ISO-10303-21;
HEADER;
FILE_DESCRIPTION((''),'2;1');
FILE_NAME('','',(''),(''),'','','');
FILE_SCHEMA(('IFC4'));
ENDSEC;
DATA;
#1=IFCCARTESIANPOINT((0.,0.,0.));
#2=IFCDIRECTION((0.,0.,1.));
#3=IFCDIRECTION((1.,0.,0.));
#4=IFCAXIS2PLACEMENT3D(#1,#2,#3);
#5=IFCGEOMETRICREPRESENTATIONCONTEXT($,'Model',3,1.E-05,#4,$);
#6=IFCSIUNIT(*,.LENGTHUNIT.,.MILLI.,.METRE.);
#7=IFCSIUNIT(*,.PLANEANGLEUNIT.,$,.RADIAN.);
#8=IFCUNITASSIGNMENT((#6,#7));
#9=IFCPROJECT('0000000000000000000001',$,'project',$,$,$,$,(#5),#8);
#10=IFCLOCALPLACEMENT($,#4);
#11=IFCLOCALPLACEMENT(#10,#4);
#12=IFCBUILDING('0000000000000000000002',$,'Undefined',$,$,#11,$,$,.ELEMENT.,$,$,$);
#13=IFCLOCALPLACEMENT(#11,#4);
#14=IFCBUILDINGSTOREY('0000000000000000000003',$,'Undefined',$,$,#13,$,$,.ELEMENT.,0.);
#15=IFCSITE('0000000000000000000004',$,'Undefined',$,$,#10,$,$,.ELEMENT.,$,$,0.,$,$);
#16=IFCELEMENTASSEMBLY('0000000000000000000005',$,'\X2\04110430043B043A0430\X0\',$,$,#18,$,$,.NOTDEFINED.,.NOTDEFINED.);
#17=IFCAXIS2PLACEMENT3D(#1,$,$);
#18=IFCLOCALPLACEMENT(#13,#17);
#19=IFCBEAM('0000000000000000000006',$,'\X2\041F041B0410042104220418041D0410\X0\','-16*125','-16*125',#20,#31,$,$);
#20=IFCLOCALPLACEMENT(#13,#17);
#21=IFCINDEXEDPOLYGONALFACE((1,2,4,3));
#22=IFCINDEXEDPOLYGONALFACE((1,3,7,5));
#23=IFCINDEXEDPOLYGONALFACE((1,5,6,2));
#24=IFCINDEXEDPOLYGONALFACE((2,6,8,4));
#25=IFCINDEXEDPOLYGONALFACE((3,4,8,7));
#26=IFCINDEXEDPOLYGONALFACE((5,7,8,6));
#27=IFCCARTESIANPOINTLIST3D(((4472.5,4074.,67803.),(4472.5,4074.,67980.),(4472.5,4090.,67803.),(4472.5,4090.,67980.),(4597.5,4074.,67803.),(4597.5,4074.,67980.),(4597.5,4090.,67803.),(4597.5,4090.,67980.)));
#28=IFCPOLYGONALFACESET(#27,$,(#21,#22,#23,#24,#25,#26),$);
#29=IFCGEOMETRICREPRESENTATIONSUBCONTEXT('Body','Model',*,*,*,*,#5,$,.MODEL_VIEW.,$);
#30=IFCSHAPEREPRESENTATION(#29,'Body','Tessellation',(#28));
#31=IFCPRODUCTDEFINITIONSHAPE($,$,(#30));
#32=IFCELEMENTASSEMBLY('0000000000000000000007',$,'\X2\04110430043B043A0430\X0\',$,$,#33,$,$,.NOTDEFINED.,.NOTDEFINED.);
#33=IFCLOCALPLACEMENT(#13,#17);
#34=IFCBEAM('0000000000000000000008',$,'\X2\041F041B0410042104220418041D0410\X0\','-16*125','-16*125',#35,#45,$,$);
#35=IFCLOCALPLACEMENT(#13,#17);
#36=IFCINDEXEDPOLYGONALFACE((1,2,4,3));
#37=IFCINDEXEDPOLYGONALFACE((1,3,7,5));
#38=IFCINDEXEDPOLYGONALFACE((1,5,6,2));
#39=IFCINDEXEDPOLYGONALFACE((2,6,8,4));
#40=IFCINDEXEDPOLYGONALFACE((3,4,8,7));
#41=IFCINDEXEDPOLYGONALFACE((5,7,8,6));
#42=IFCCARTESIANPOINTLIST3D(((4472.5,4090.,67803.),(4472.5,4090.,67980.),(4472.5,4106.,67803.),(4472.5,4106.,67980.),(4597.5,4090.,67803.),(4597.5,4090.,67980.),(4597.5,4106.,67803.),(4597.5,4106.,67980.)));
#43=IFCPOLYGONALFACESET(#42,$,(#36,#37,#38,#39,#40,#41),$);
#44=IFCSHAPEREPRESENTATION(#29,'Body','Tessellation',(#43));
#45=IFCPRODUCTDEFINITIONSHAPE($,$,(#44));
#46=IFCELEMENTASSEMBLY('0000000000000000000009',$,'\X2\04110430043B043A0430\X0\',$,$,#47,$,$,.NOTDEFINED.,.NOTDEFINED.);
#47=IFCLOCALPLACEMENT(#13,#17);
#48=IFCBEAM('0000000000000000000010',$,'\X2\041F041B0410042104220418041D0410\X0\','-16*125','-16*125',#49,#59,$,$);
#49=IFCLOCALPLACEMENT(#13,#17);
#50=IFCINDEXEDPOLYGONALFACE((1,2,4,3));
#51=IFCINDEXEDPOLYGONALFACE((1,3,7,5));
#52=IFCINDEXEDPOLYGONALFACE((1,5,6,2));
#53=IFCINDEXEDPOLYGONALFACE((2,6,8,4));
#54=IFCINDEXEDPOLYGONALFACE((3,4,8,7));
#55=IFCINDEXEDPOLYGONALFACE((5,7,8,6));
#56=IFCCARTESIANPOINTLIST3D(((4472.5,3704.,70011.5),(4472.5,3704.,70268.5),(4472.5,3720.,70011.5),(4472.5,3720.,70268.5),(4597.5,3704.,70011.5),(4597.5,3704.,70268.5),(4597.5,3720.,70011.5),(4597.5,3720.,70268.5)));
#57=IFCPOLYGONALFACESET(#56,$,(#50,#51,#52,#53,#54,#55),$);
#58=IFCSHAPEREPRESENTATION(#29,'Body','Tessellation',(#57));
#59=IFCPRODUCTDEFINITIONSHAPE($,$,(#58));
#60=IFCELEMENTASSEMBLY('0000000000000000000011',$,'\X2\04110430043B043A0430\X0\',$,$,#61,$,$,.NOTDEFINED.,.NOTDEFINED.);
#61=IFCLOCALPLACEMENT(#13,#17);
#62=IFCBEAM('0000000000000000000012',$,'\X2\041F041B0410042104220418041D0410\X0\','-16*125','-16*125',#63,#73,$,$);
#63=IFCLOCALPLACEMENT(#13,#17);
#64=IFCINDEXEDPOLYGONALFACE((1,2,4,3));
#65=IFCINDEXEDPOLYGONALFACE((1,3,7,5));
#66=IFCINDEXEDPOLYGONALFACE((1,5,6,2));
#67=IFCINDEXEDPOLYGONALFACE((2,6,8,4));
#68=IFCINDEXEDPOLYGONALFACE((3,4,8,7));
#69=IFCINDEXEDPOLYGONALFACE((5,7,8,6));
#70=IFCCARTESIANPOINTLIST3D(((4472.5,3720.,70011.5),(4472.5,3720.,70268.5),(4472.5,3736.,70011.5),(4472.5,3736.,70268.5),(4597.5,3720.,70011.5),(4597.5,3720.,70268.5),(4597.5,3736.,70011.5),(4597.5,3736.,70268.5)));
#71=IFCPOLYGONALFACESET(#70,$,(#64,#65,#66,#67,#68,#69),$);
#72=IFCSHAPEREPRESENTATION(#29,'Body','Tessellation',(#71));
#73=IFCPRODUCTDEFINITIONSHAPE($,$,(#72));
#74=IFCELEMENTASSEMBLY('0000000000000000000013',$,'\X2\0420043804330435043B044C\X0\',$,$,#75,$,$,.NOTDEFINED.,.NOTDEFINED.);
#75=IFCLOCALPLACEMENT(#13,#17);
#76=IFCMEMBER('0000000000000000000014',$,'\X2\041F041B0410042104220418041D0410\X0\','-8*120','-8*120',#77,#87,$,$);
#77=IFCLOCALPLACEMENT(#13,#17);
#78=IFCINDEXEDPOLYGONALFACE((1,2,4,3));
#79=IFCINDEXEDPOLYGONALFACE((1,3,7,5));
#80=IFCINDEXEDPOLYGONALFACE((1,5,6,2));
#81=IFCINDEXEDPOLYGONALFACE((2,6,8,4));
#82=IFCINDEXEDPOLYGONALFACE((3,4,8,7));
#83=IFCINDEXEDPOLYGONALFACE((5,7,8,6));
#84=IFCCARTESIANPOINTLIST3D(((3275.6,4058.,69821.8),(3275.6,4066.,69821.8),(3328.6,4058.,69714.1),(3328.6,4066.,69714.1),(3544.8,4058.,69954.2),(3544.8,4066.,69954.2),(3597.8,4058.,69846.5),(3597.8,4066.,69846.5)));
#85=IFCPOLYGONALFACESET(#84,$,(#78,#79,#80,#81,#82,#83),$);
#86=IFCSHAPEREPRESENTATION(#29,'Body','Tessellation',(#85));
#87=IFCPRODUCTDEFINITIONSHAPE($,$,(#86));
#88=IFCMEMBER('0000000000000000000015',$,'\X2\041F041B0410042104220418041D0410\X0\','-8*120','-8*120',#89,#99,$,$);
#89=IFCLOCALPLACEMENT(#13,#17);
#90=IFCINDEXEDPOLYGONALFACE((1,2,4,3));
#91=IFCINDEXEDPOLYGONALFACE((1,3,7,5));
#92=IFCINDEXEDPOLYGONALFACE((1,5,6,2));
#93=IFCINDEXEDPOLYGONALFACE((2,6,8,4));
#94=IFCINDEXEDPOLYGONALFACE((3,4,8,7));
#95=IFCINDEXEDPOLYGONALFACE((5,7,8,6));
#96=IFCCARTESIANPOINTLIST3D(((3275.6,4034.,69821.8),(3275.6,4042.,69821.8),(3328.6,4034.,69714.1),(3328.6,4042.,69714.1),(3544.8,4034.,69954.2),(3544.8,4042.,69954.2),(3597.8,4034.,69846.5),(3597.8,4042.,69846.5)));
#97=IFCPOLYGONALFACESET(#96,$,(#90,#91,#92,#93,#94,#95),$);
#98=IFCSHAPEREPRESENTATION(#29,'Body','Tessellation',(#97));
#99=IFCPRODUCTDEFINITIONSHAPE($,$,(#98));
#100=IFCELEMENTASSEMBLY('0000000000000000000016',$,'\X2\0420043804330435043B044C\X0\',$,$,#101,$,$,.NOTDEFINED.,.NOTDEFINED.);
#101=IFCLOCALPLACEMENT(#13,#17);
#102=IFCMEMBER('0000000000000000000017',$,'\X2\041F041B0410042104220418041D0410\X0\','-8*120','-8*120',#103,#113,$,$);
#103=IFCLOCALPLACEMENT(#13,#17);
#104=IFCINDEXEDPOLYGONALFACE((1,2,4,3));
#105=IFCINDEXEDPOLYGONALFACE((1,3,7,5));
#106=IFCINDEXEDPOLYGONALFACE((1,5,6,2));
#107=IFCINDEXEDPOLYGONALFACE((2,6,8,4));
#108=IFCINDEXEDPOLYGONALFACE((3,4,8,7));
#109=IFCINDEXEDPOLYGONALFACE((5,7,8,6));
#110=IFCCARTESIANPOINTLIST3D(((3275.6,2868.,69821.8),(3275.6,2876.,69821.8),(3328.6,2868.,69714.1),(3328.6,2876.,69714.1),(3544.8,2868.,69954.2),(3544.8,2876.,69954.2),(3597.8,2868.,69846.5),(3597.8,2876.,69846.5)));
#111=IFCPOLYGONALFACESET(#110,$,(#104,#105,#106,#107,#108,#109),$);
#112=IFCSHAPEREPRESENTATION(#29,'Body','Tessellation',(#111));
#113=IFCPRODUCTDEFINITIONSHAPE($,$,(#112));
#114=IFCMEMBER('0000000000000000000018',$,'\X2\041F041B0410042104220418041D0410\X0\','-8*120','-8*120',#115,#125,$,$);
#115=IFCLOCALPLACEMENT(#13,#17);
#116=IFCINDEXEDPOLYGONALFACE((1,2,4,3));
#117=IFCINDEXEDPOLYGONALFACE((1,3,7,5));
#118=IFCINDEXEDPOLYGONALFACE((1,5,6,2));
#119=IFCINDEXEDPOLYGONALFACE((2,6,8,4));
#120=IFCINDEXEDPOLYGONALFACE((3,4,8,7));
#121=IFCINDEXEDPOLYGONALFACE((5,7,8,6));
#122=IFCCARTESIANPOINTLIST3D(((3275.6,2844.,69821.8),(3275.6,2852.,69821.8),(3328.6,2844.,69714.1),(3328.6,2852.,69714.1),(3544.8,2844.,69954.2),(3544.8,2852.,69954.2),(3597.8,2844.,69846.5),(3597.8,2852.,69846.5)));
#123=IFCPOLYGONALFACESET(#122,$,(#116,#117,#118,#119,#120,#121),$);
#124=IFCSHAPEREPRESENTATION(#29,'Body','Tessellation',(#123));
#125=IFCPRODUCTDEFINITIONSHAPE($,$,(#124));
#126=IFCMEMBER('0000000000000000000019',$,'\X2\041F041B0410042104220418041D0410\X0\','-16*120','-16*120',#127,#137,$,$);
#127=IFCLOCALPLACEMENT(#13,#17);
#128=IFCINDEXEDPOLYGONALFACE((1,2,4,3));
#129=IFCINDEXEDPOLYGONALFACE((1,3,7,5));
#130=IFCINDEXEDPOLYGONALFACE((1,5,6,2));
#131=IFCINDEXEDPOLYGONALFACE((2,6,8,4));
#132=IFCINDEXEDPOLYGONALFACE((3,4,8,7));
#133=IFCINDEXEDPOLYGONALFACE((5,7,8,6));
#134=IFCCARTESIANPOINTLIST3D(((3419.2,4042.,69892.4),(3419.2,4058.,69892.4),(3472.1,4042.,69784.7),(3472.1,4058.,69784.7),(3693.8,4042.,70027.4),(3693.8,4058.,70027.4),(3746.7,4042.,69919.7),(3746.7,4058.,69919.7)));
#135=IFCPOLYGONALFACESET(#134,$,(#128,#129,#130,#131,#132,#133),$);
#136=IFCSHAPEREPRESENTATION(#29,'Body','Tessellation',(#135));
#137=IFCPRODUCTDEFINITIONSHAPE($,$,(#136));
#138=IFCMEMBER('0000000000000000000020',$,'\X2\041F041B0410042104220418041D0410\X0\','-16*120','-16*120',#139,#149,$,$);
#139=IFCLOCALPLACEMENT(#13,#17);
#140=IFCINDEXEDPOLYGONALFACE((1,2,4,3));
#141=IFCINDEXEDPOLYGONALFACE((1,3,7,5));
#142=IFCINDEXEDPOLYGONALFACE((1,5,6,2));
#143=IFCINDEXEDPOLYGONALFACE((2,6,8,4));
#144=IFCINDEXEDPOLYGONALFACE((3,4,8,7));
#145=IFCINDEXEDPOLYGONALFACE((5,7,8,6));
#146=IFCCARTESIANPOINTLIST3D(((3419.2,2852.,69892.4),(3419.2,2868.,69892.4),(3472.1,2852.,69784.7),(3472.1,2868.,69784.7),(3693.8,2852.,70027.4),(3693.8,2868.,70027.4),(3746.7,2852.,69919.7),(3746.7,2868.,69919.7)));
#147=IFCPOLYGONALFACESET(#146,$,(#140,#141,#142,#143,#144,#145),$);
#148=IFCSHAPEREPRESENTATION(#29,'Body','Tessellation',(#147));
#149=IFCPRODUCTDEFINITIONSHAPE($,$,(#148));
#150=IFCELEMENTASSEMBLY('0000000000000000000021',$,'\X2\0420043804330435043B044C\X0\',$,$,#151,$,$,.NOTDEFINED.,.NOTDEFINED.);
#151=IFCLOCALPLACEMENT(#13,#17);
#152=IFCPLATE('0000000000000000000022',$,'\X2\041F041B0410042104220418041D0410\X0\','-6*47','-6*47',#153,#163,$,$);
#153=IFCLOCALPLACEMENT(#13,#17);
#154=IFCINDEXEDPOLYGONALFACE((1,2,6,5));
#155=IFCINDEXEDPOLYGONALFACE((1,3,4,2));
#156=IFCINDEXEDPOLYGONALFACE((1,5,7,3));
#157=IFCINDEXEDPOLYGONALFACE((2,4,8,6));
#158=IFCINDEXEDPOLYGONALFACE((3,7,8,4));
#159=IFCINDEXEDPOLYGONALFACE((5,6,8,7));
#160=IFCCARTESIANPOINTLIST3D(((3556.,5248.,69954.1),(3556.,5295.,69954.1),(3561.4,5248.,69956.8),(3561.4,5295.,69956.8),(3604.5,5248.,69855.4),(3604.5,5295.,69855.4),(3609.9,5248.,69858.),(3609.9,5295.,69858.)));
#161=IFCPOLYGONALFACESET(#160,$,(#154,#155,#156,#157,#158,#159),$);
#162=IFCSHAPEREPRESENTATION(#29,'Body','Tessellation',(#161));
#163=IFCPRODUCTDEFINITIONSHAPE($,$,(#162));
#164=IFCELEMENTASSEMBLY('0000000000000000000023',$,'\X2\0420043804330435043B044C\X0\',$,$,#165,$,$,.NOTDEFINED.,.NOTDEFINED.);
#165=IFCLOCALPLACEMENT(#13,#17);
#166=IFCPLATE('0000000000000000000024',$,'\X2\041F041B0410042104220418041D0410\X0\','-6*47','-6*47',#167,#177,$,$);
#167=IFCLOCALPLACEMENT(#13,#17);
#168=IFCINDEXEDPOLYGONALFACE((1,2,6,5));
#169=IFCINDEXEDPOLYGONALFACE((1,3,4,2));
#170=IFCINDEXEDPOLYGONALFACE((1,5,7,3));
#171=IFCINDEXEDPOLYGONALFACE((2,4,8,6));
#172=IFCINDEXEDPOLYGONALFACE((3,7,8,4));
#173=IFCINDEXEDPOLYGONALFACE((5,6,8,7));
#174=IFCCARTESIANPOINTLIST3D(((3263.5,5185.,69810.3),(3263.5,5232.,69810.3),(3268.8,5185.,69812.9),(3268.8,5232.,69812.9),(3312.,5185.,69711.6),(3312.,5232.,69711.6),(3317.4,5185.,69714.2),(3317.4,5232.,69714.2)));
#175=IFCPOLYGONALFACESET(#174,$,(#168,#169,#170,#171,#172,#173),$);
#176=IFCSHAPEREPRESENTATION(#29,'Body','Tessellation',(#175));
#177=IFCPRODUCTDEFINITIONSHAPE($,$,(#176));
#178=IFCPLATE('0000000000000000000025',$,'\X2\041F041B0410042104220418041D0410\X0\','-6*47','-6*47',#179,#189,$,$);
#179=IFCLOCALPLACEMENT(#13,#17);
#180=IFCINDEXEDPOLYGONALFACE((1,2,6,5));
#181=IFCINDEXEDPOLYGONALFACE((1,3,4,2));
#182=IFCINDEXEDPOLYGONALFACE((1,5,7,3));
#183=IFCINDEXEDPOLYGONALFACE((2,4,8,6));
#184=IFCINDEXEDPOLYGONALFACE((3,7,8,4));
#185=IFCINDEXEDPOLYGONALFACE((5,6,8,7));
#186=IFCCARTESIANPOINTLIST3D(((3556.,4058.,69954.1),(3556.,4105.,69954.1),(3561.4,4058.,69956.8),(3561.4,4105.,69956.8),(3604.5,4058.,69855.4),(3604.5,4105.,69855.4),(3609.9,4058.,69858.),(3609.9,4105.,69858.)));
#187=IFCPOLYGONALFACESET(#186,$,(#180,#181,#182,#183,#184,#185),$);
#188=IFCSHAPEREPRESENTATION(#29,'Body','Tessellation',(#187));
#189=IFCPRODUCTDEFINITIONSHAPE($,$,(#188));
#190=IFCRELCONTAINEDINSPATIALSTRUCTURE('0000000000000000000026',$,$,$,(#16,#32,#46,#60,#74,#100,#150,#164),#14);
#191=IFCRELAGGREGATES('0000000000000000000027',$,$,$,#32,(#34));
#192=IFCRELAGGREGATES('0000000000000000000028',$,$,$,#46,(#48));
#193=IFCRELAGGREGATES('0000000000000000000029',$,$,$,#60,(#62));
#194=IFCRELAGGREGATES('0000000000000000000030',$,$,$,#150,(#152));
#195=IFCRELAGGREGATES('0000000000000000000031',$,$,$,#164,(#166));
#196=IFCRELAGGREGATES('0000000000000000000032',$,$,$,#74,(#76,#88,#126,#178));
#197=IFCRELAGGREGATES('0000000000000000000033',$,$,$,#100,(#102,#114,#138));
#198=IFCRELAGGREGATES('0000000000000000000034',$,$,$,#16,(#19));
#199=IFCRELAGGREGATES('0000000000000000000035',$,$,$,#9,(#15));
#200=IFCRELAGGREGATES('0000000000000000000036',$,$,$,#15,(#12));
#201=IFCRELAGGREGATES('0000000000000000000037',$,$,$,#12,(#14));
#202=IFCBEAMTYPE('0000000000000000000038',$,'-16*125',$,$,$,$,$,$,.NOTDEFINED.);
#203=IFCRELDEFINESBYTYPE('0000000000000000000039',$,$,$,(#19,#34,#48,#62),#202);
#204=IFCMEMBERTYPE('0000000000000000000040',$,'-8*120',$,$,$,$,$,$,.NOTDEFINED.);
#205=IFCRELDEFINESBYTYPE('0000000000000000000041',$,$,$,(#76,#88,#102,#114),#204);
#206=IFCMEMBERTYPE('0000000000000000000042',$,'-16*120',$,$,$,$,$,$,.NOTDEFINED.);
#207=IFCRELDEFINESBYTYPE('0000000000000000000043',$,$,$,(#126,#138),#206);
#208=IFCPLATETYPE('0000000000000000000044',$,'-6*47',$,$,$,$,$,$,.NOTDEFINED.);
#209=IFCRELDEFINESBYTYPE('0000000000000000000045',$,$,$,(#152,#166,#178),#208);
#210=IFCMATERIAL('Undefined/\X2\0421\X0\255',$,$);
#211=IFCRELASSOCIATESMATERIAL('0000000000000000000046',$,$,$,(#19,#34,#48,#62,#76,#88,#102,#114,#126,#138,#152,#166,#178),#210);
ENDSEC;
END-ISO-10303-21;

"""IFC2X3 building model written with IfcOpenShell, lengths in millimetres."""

from ifc_helpers import new_model, si_unit, frame, origin_with_axes, origin_2d_with_axis, place, context, subcontext, project, spatial, polyline, rectangle, outline, extrude, boolean, material, type_object, element, aggregate, save


model = new_model("IFC2X3")

# Units and contexts
model_context = context("Model", 3, precision=1e-05, world=origin_with_axes())
body_context = subcontext(model_context, "Body", "Model", "MODEL_VIEW")
ifc_project = project(units=[si_unit("LENGTHUNIT", "METRE", prefix="MILLI"), si_unit("PLANEANGLEUNIT", "RADIAN")], contexts=[model_context])

# Site, building, storey
site_placement = place(None, origin_with_axes())
site = spatial("IfcSite", under=ifc_project, at=site_placement, Name="Undefined", CompositionType="ELEMENT", RefElevation=0.0)
building_placement = place(site_placement, origin_with_axes())
building = spatial("IfcBuilding", under=site, at=building_placement, Name="Undefined", CompositionType="ELEMENT")
storey_placement = place(building_placement, origin_with_axes())
storey = spatial("IfcBuildingStorey", under=building, at=storey_placement, Name="Undefined", CompositionType="ELEMENT", Elevation=0.0)

# Element assemblies, beams
assembly_1_placement = place(storey_placement, origin_with_axes())
assembly_1 = element("IfcElementAssembly", 1, at=assembly_1_placement, inside=storey, Name="Балка", AssemblyPlace="NOTDEFINED", PredefinedType="NOTDEFINED")
ifc_material_1 = material(Name="Undefined/С255")
beam_type = type_object("IfcBeamType", Name="-16*125", PredefinedType="NOTDEFINED")
beam_1_placement = place(assembly_1_placement, frame((4535.0, 4082.0, 67803.0), z_axis=(-1.0, 0.0, 0.0), x_axis=(0.0, 0.0, 1.0)))
beam_1 = element("IfcBeam", 2, at=beam_1_placement, type_object=beam_type, material=ifc_material_1, Name="ПЛАСТИНА", Description="-16*125", ObjectType="-16*125", context=body_context, shape_type="SweptSolid", body=[
    extrude(rectangle(XDim=16.0, YDim=125.0, at=origin_2d_with_axis()), frame((177.0, 0.0, 0.0), z_axis=(-1.0, 0.0, 0.0), x_axis=(0.0, -1.0, 0.0)), (0.0, 0.0, 1.0), 177.0),
])
assembly_2_placement = place(storey_placement, origin_with_axes())
assembly_2 = element("IfcElementAssembly", 3, at=assembly_2_placement, inside=storey, Name="Балка", AssemblyPlace="NOTDEFINED", PredefinedType="NOTDEFINED")
beam_2_placement = place(assembly_2_placement, frame((4535.0, 4098.0, 67803.0), z_axis=(-1.0, 0.0, 0.0), x_axis=(0.0, 0.0, 1.0)))
beam_2 = element("IfcBeam", 4, at=beam_2_placement, type_object=beam_type, material=ifc_material_1, Name="ПЛАСТИНА", Description="-16*125", ObjectType="-16*125", context=body_context, shape_type="SweptSolid", body=[
    extrude(rectangle(XDim=16.0, YDim=125.0, at=origin_2d_with_axis()), frame((177.0, 0.0, 0.0), z_axis=(-1.0, 0.0, 0.0), x_axis=(0.0, -1.0, 0.0)), (0.0, 0.0, 1.0), 177.0),
])
aggregate(assembly_2, [beam_2])
assembly_3_placement = place(storey_placement, origin_with_axes())
assembly_3 = element("IfcElementAssembly", 5, at=assembly_3_placement, inside=storey, Name="Балка", AssemblyPlace="NOTDEFINED", PredefinedType="NOTDEFINED")
beam_3_placement = place(assembly_3_placement, frame((4535.0, 3712.0, 70011.5), z_axis=(-1.0, 0.0, 0.0), x_axis=(0.0, 0.0, 1.0)))
beam_3 = element("IfcBeam", 6, at=beam_3_placement, type_object=beam_type, material=ifc_material_1, Name="ПЛАСТИНА", Description="-16*125", ObjectType="-16*125", context=body_context, shape_type="SweptSolid", body=[
    extrude(rectangle(XDim=16.0, YDim=125.0, at=origin_2d_with_axis()), frame((257.0, 0.0, 0.0), z_axis=(-1.0, 0.0, 0.0), x_axis=(0.0, -1.0, 0.0)), (0.0, 0.0, 1.0), 257.0),
])
aggregate(assembly_3, [beam_3])
assembly_4_placement = place(storey_placement, origin_with_axes())
assembly_4 = element("IfcElementAssembly", 7, at=assembly_4_placement, inside=storey, Name="Балка", AssemblyPlace="NOTDEFINED", PredefinedType="NOTDEFINED")
beam_4_placement = place(assembly_4_placement, frame((4535.0, 3728.0, 70011.5), z_axis=(-1.0, 0.0, 0.0), x_axis=(0.0, 0.0, 1.0)))
beam_4 = element("IfcBeam", 8, at=beam_4_placement, type_object=beam_type, material=ifc_material_1, Name="ПЛАСТИНА", Description="-16*125", ObjectType="-16*125", context=body_context, shape_type="SweptSolid", body=[
    extrude(rectangle(XDim=16.0, YDim=125.0, at=origin_2d_with_axis()), frame((257.0, 0.0, 0.0), z_axis=(-1.0, 0.0, 0.0), x_axis=(0.0, -1.0, 0.0)), (0.0, 0.0, 1.0), 257.0),
])
aggregate(assembly_4, [beam_4])

# Element assemblies, members
assembly_5_placement = place(storey_placement, origin_with_axes())
assembly_5 = element("IfcElementAssembly", 9, at=assembly_5_placement, inside=storey, Name="Ригель", AssemblyPlace="NOTDEFINED", PredefinedType="NOTDEFINED")
member_type_1 = type_object("IfcMemberType", Name="-8*120", PredefinedType="NOTDEFINED")
member_1_placement = place(assembly_5_placement, frame((3302.1, 4062.0, 69768.0), z_axis=(0.441221, 0.0, -0.897399), x_axis=(0.897399, 0.0, 0.441221)))
member_1 = element("IfcMember", 10, at=member_1_placement, type_object=member_type_1, material=ifc_material_1, Name="ПЛАСТИНА", Description="-8*120", ObjectType="-8*120", context=body_context, shape_type="SweptSolid", body=[
    extrude(rectangle(XDim=8.0, YDim=120.0, at=origin_2d_with_axis()), frame((300.0, 0.0, 0.0), z_axis=(-1.0, 0.0, 0.0), x_axis=(0.0, -1.0, 0.0)), (0.0, 0.0, 1.0), 300.0),
])
member_2_placement = place(assembly_5_placement, frame((3302.1, 4038.0, 69768.0), z_axis=(0.441221, 0.0, -0.897399), x_axis=(0.897399, 0.0, 0.441221)))
member_2 = element("IfcMember", 11, at=member_2_placement, type_object=member_type_1, material=ifc_material_1, Name="ПЛАСТИНА", Description="-8*120", ObjectType="-8*120", context=body_context, shape_type="SweptSolid", body=[
    extrude(rectangle(XDim=8.0, YDim=120.0, at=origin_2d_with_axis()), frame((300.0, 0.0, 0.0), z_axis=(-1.0, 0.0, 0.0), x_axis=(0.0, -1.0, 0.0)), (0.0, 0.0, 1.0), 300.0),
])
assembly_6_placement = place(storey_placement, origin_with_axes())
assembly_6 = element("IfcElementAssembly", 12, at=assembly_6_placement, inside=storey, Name="Ригель", AssemblyPlace="NOTDEFINED", PredefinedType="NOTDEFINED")
member_3_placement = place(assembly_6_placement, frame((3302.1, 2872.0, 69768.0), z_axis=(0.441221, 0.0, -0.897399), x_axis=(0.897399, 0.0, 0.441221)))
member_3 = element("IfcMember", 13, at=member_3_placement, type_object=member_type_1, material=ifc_material_1, Name="ПЛАСТИНА", Description="-8*120", ObjectType="-8*120", context=body_context, shape_type="SweptSolid", body=[
    extrude(rectangle(XDim=8.0, YDim=120.0, at=origin_2d_with_axis()), frame((300.0, 0.0, 0.0), z_axis=(-1.0, 0.0, 0.0), x_axis=(0.0, -1.0, 0.0)), (0.0, 0.0, 1.0), 300.0),
])
member_4_placement = place(assembly_6_placement, frame((3302.1, 2848.0, 69768.0), z_axis=(0.441221, 0.0, -0.897399), x_axis=(0.897399, 0.0, 0.441221)))
member_4 = element("IfcMember", 14, at=member_4_placement, type_object=member_type_1, material=ifc_material_1, Name="ПЛАСТИНА", Description="-8*120", ObjectType="-8*120", context=body_context, shape_type="SweptSolid", body=[
    extrude(rectangle(XDim=8.0, YDim=120.0, at=origin_2d_with_axis()), frame((300.0, 0.0, 0.0), z_axis=(-1.0, 0.0, 0.0), x_axis=(0.0, -1.0, 0.0)), (0.0, 0.0, 1.0), 300.0),
])

# Members
member_type_2 = type_object("IfcMemberType", Name="-16*120", PredefinedType="NOTDEFINED")
member_5_placement = place(assembly_5_placement, frame((3445.7, 4050.0, 69838.6), z_axis=(0.441221, 0.0, -0.897399), x_axis=(0.897399, 0.0, 0.441221)))
member_5 = element("IfcMember", 15, at=member_5_placement, type_object=member_type_2, material=ifc_material_1, Name="ПЛАСТИНА", Description="-16*120", ObjectType="-16*120", context=body_context, shape_type="SweptSolid", body=[
    extrude(rectangle(XDim=16.0, YDim=120.0, at=origin_2d_with_axis()), frame((306.0, 0.0, 0.0), z_axis=(-1.0, 0.0, 0.0), x_axis=(0.0, -1.0, 0.0)), (0.0, 0.0, 1.0), 306.0),
])
member_6_placement = place(assembly_6_placement, frame((3445.7, 2860.0, 69838.6), z_axis=(0.441221, 0.0, -0.897399), x_axis=(0.897399, 0.0, 0.441221)))
member_6 = element("IfcMember", 16, at=member_6_placement, type_object=member_type_2, material=ifc_material_1, Name="ПЛАСТИНА", Description="-16*120", ObjectType="-16*120", context=body_context, shape_type="SweptSolid", body=[
    extrude(rectangle(XDim=16.0, YDim=120.0, at=origin_2d_with_axis()), frame((306.0, 0.0, 0.0), z_axis=(-1.0, 0.0, 0.0), x_axis=(0.0, -1.0, 0.0)), (0.0, 0.0, 1.0), 306.0),
])

# Element assemblies, plates
assembly_7_placement = place(storey_placement, origin_with_axes())
assembly_7 = element("IfcElementAssembly", 17, at=assembly_7_placement, inside=storey, Name="Ригель", AssemblyPlace="NOTDEFINED", PredefinedType="NOTDEFINED")
plate_type = type_object("IfcPlateType", Name="-6*47", PredefinedType="NOTDEFINED")
plate_1_placement = place(assembly_7_placement, frame((3607.2, 5185.0, 69856.7), z_axis=(-0.897399, 0.0, -0.441221), x_axis=(-0.441221, 0.0, 0.897399)))
plate_1 = element("IfcPlate", 18, at=plate_1_placement, type_object=plate_type, material=ifc_material_1, Name="ПЛАСТИНА", Description="-6*47", ObjectType="-6*47", context=body_context, shape_type="CSG", body=[
    boolean("DIFFERENCE", extrude(outline(polyline([(0.0, 0.0), (110.0, 0.0), (110.0, 110.0), (0.0, 110.0), (0.0, 0.0)])), frame((0.0, 0.0, -3.0), z_axis=(0.0, 0.0, 1.0), x_axis=(1.0, 0.0, 0.0)), (0.0, 0.0, 1.0), 6.0), extrude(rectangle(XDim=26.0, YDim=130.0, at=origin_2d_with_axis()), frame((55.0, -3.0, 0.0), z_axis=(0.0, 1.0, 0.0), x_axis=(0.0, 0.0, -1.0)), (0.0, 0.0, 1.0), 66.0)),
])
aggregate(assembly_7, [plate_1])
assembly_8_placement = place(storey_placement, origin_with_axes())
assembly_8 = element("IfcElementAssembly", 19, at=assembly_8_placement, inside=storey, Name="Ригель", AssemblyPlace="NOTDEFINED", PredefinedType="NOTDEFINED")
plate_2_placement = place(assembly_8_placement, frame((3266.1, 5185.0, 69811.6), z_axis=(0.897399, 0.0, 0.441221), x_axis=(0.441221, 0.0, -0.897399)))
plate_2 = element("IfcPlate", 20, at=plate_2_placement, type_object=plate_type, material=ifc_material_1, Name="ПЛАСТИНА", Description="-6*47", ObjectType="-6*47", context=body_context, shape_type="CSG", body=[
    boolean("DIFFERENCE", extrude(outline(polyline([(0.0, 0.0), (110.0, 0.0), (110.0, 110.0), (0.0, 110.0), (0.0, 0.0)])), frame((0.0, 0.0, -3.0), z_axis=(0.0, 0.0, 1.0), x_axis=(1.0, 0.0, 0.0)), (0.0, 0.0, 1.0), 6.0), extrude(rectangle(XDim=26.0, YDim=130.0, at=origin_2d_with_axis()), frame((55.0, 47.0, 0.0), z_axis=(0.0, 1.0, 0.0), x_axis=(0.0, 0.0, -1.0)), (0.0, 0.0, 1.0), 66.0)),
])
aggregate(assembly_8, [plate_2])

# Plate
plate_3_placement = place(assembly_5_placement, frame((3607.2, 3995.0, 69856.7), z_axis=(-0.897399, 0.0, -0.441221), x_axis=(-0.441221, 0.0, 0.897399)))
plate_3 = element("IfcPlate", 21, at=plate_3_placement, type_object=plate_type, material=ifc_material_1, Name="ПЛАСТИНА", Description="-6*47", ObjectType="-6*47", context=body_context, shape_type="CSG", body=[
    boolean("DIFFERENCE", extrude(outline(polyline([(0.0, 0.0), (110.0, 0.0), (110.0, 110.0), (0.0, 110.0), (0.0, 0.0)])), frame((0.0, 0.0, -3.0), z_axis=(0.0, 0.0, 1.0), x_axis=(1.0, 0.0, 0.0)), (0.0, 0.0, 1.0), 6.0), extrude(rectangle(XDim=26.0, YDim=130.0, at=origin_2d_with_axis()), frame((55.0, -3.0, 0.0), z_axis=(0.0, 1.0, 0.0), x_axis=(0.0, 0.0, -1.0)), (0.0, 0.0, 1.0), 66.0)),
])

aggregate(assembly_5, [member_1, member_2, member_5, plate_3])
aggregate(assembly_6, [member_3, member_4, member_6])
aggregate(assembly_1, [beam_1])

save(model, "model.ifc")
